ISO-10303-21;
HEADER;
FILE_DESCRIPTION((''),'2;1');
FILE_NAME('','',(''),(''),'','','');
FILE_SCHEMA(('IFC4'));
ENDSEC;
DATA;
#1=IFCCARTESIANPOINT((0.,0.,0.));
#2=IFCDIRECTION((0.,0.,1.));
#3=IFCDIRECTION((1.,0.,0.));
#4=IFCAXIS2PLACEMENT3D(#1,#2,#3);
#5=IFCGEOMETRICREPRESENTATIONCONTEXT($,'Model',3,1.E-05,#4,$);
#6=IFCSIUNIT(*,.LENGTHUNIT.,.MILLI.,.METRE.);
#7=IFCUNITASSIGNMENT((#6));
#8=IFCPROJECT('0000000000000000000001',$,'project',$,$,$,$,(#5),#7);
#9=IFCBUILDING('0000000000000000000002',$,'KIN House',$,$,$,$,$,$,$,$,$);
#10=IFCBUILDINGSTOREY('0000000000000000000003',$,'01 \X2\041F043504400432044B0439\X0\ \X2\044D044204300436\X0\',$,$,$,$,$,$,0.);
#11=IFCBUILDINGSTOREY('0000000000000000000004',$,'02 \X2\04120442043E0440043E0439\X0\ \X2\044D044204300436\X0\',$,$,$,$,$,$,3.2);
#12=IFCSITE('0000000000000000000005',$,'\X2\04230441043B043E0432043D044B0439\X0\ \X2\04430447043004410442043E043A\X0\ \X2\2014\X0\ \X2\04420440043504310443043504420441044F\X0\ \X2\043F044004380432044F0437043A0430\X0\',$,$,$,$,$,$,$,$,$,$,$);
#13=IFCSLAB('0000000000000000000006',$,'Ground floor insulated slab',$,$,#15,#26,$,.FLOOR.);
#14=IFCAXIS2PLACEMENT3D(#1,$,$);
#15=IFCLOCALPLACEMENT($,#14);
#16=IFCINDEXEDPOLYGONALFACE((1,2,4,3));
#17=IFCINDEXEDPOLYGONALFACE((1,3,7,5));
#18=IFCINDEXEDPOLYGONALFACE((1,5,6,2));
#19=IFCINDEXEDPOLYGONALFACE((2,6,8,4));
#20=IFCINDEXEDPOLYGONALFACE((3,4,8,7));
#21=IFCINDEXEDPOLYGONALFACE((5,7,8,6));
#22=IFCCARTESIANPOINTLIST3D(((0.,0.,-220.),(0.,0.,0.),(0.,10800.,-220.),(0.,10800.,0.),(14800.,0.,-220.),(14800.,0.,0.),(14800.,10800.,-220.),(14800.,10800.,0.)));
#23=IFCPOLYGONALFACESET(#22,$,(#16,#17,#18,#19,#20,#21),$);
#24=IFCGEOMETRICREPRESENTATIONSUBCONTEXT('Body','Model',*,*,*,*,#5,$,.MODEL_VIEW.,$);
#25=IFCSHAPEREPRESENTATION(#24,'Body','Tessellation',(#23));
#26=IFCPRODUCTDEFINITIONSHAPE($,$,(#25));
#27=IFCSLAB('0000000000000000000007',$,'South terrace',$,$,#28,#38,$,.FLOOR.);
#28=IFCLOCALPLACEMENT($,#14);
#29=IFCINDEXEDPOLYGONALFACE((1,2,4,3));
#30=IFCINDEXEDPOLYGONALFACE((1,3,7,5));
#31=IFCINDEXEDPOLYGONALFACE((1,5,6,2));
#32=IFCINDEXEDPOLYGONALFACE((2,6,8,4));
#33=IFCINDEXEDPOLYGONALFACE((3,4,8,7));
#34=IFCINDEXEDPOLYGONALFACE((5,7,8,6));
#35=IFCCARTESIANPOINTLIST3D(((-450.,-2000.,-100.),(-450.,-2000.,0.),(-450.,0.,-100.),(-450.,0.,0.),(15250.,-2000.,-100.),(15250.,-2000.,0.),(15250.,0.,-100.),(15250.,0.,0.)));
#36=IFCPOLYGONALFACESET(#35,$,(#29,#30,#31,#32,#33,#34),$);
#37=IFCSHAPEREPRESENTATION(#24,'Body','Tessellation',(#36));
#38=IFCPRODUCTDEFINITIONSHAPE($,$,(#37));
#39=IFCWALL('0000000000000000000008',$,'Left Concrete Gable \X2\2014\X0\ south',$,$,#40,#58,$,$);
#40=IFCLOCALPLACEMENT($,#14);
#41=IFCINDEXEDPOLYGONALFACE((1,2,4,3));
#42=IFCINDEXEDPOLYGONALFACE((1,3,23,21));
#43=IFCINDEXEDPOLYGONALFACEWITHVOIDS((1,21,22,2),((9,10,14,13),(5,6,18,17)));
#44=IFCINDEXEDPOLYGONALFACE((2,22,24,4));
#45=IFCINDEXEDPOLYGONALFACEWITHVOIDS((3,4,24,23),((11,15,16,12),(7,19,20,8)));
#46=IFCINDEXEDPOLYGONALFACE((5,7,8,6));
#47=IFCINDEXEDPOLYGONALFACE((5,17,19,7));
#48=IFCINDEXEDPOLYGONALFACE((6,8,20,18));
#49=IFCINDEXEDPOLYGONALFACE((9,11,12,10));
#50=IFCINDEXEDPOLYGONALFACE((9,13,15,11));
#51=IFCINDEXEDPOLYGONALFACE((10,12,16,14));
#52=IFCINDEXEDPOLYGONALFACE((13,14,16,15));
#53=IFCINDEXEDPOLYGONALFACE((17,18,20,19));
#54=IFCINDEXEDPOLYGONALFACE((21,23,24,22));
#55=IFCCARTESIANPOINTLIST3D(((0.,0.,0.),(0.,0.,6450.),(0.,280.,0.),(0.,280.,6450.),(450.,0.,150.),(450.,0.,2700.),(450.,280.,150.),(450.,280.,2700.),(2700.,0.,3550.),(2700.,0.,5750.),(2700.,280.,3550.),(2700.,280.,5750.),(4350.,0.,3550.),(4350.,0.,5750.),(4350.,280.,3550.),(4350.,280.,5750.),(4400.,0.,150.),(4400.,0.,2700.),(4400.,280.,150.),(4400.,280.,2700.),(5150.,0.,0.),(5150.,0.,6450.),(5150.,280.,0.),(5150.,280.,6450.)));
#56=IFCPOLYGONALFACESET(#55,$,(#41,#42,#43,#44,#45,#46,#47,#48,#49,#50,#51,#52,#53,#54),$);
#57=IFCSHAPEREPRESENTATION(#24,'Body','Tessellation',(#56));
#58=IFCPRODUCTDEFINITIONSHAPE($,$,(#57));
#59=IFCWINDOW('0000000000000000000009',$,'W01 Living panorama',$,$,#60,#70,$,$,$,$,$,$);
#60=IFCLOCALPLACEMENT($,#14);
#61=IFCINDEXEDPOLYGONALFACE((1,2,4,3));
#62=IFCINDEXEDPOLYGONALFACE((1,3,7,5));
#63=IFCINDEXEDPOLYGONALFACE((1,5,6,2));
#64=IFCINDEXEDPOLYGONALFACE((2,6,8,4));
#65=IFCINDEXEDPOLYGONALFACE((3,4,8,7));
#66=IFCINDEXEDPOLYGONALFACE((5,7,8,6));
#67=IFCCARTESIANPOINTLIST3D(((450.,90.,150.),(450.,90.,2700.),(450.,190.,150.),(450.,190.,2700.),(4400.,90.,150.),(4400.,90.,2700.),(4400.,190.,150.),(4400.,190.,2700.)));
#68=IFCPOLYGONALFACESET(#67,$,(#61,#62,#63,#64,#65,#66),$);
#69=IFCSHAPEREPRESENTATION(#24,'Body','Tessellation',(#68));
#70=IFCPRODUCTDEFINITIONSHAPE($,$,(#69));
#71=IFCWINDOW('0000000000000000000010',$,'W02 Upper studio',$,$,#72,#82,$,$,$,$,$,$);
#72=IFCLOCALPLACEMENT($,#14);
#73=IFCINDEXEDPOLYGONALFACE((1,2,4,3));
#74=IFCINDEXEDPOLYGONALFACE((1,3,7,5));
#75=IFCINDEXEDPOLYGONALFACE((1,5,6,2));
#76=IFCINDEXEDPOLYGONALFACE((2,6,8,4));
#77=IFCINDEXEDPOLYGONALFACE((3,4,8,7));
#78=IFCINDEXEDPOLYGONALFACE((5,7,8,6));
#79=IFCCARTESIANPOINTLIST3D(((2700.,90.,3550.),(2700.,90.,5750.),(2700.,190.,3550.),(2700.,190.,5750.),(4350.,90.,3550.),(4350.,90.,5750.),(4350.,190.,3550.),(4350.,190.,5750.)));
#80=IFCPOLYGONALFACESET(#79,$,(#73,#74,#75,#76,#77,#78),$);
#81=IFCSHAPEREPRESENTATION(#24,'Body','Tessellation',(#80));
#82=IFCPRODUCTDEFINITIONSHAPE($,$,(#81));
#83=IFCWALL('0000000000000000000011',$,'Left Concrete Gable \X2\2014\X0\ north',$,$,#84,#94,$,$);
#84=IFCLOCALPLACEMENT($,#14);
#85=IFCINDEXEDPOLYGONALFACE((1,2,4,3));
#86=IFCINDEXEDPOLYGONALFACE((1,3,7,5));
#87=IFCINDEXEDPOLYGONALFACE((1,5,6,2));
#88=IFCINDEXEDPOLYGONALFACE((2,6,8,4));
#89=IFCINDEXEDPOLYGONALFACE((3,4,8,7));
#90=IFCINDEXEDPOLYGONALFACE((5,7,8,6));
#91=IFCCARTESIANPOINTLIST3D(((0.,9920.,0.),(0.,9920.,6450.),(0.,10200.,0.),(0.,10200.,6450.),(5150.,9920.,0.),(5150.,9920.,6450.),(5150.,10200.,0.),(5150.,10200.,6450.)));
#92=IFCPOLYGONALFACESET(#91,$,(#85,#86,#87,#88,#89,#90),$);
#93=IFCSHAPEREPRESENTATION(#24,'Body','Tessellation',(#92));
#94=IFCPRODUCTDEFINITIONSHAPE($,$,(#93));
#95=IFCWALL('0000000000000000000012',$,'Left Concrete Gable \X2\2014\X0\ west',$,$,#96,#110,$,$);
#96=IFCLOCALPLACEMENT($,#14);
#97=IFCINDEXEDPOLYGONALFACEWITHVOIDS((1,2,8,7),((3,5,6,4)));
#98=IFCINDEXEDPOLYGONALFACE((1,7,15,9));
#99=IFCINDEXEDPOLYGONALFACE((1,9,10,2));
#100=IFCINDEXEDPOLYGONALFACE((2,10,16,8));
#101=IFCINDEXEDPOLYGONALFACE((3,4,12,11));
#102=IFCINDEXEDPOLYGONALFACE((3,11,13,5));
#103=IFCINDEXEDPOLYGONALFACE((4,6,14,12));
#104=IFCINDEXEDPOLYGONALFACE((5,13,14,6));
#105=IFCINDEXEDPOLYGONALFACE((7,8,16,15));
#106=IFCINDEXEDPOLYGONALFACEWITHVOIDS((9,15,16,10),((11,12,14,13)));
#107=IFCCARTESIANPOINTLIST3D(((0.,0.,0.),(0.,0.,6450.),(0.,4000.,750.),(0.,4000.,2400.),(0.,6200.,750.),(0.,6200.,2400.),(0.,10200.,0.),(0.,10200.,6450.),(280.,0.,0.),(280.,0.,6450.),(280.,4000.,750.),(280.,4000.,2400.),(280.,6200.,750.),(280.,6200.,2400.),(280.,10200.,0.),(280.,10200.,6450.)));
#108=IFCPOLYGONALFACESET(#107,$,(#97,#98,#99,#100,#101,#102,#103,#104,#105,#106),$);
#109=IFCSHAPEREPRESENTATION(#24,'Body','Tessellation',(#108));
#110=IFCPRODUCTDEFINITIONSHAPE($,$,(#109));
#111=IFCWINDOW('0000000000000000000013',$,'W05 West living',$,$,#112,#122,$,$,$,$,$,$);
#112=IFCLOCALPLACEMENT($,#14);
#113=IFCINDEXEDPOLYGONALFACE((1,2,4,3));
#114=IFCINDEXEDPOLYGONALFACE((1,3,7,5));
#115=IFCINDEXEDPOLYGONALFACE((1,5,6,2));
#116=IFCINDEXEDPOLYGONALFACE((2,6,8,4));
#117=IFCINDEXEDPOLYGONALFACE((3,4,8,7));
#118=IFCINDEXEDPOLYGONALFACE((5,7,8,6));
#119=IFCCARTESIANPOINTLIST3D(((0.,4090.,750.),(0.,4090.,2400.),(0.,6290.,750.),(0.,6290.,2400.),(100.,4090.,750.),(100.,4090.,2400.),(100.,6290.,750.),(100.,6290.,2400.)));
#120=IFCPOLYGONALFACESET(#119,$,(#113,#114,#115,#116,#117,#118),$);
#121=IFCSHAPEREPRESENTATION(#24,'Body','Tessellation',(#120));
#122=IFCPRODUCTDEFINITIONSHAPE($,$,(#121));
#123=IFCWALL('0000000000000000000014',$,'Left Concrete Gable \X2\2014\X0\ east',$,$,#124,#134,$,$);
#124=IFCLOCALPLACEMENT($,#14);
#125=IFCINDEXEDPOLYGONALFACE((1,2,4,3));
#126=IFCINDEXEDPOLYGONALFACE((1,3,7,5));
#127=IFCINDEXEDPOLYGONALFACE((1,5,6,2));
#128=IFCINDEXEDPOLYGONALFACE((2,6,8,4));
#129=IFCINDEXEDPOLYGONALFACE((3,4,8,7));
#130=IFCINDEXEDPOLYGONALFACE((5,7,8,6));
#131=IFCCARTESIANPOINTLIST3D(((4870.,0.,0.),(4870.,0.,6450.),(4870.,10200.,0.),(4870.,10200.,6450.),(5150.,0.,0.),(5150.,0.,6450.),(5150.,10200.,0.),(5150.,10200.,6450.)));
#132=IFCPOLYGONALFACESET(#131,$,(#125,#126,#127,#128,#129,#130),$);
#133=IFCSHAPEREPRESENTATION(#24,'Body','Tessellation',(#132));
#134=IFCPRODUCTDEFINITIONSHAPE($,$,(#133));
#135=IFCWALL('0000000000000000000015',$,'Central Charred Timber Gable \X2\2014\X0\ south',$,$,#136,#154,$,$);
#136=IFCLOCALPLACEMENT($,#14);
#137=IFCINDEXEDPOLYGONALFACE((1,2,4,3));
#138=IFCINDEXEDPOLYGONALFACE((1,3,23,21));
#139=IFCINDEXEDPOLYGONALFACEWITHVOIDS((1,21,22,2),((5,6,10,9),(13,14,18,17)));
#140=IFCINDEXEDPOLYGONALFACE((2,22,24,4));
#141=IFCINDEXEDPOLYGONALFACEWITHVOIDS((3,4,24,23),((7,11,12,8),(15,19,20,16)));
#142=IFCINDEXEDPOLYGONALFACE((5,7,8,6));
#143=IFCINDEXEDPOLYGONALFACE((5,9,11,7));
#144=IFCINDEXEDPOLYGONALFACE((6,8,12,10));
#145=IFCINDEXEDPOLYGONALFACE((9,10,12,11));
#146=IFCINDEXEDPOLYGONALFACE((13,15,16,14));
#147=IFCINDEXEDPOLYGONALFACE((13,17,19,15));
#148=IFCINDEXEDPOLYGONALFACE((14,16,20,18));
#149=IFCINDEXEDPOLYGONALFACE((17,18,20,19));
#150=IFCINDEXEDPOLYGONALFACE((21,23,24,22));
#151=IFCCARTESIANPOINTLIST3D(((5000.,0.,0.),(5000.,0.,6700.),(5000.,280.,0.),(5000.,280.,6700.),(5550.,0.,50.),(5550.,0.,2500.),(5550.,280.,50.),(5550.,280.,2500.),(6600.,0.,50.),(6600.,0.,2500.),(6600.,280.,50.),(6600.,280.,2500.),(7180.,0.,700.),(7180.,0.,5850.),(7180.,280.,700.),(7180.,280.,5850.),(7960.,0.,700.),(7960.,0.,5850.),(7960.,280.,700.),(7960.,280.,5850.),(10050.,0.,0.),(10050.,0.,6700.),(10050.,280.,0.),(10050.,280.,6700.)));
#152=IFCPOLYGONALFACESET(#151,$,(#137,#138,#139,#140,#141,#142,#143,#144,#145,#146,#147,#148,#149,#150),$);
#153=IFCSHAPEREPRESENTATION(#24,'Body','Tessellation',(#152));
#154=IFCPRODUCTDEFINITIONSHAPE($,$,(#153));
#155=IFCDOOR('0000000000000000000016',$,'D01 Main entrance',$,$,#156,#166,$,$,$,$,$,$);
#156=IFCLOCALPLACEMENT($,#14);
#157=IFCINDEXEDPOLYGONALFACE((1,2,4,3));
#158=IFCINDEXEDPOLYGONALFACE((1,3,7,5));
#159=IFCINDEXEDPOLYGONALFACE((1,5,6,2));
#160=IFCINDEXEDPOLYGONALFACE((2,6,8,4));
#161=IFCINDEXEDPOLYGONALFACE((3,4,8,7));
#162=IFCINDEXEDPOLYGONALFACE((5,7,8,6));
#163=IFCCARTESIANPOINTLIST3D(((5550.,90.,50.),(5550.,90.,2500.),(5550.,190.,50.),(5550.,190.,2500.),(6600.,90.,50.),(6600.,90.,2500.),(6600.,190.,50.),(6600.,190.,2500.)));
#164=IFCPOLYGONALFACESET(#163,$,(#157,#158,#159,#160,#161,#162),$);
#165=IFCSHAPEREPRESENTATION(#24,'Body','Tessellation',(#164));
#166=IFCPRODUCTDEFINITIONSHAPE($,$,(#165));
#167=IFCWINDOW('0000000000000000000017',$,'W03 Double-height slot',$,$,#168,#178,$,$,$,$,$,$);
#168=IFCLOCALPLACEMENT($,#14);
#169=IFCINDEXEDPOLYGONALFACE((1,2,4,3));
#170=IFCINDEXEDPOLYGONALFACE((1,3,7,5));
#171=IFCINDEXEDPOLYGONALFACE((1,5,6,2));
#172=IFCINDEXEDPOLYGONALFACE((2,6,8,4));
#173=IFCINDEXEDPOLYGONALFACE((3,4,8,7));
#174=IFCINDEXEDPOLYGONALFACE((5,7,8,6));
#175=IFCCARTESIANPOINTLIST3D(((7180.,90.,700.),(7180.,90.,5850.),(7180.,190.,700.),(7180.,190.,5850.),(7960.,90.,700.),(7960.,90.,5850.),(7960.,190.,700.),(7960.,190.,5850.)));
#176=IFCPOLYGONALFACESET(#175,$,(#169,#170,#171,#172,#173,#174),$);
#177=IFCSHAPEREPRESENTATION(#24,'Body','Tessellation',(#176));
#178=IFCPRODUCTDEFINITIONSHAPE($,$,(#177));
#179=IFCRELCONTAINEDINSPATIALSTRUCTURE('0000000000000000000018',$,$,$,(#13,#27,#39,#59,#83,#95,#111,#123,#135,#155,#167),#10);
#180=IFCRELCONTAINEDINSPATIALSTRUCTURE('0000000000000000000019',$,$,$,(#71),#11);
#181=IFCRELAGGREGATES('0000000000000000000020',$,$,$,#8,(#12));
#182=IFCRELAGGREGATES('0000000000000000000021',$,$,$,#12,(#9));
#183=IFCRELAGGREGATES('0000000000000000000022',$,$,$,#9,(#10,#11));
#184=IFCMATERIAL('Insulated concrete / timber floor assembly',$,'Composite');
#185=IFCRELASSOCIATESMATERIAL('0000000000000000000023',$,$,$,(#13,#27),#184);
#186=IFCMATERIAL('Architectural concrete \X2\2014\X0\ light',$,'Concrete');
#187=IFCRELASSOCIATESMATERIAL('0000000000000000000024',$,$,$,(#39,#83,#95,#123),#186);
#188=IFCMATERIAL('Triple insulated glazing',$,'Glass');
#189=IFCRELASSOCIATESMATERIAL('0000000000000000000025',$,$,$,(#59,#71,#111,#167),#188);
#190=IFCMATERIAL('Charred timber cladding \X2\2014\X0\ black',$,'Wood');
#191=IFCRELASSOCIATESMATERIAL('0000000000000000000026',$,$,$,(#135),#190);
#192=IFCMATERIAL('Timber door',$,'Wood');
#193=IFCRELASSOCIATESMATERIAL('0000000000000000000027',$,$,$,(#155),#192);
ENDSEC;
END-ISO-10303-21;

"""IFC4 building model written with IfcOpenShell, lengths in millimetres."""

from ifc_helpers import new_model, si_unit, frame, origin_with_axes, place, context, subcontext, project, spatial, indexed_curve, outline, extrude, material, element, fill, save


model = new_model("IFC4")

# Units and contexts
model_context = context("Model", 3, precision=1e-05, world=origin_with_axes())
body_context = subcontext(model_context, "Body", "Model", "MODEL_VIEW")
ifc_project = project(units=[si_unit("LENGTHUNIT", "METRE", prefix="MILLI")], contexts=[model_context])

# Site, building, storey
site = spatial("IfcSite", under=ifc_project, Name="Условный участок — требуется привязка")
building = spatial("IfcBuilding", under=site, Name="KIN House")
storey_1 = spatial("IfcBuildingStorey", under=building, Name="01 Первый этаж", Elevation=0.0)

# Slabs
ifc_material_1 = material(Name="Insulated concrete / timber floor assembly", Category="Composite")
slab_1_placement = place(None, frame((0.0, 0.0, -220.0), z_axis=(0.0, 0.0, 1.0), x_axis=(1.0, 0.0, 0.0)))
element("IfcSlab", 1, at=slab_1_placement, inside=storey_1, material=ifc_material_1, Name="Ground floor insulated slab", PredefinedType="FLOOR", context=body_context, shape_type="SweptSolid", body=[
    extrude(outline(indexed_curve([(0.0, 0.0), (14800.0, 0.0), (14800.0, 10800.0), (0.0, 10800.0)])), None, (0.0, 0.0, 1.0), 220.0),
])
slab_2_placement = place(None, frame((-450.0, -2000.0, -100.0), z_axis=(0.0, 0.0, 1.0), x_axis=(1.0, 0.0, 0.0)))
element("IfcSlab", 2, at=slab_2_placement, inside=storey_1, material=ifc_material_1, Name="South terrace", PredefinedType="FLOOR", context=body_context, shape_type="SweptSolid", body=[
    extrude(outline(indexed_curve([(0.0, 0.0), (15700.0, 0.0), (15700.0, 2000.0), (0.0, 2000.0)])), None, (0.0, 0.0, 1.0), 100.0),
])

# Wall, openings, window
ifc_material_2 = material(Name="Architectural concrete — light", Category="Concrete")
wall_1_placement = place(None, origin_with_axes())
wall_1 = element("IfcWall", 3, at=wall_1_placement, inside=storey_1, material=ifc_material_2, Name="Left Concrete Gable — south", context=body_context, shape_type="SweptSolid", body=[
    extrude(outline(indexed_curve([(0.0, 0.0), (0.0, 280.0), (5150.0, 280.0), (5150.0, 0.0), (0.0, 0.0)], self_intersect=False)), origin_with_axes(), (0.0, 0.0, 1.0), 6450.0),
])
opening_1_placement = place(wall_1_placement, frame((450.0, 0.0, 150.0), z_axis=(0.0, 0.0, 1.0), x_axis=(1.0, 0.0, 0.0)))
opening_1 = element("IfcOpeningElement", 4, at=opening_1_placement, cuts=wall_1, context=body_context, shape_type="SweptSolid", body=[
    extrude(outline(indexed_curve([(0.0, 0.0), (0.0, 380.0), (3950.0, 380.0), (3950.0, 0.0), (0.0, 0.0)], self_intersect=False)), origin_with_axes(), (0.0, 0.0, 1.0), 2550.0),
])
opening_2_placement = place(wall_1_placement, frame((2700.0, 0.0, 3550.0), z_axis=(0.0, 0.0, 1.0), x_axis=(1.0, 0.0, 0.0)))
opening_2 = element("IfcOpeningElement", 5, at=opening_2_placement, cuts=wall_1, context=body_context, shape_type="SweptSolid", body=[
    extrude(outline(indexed_curve([(0.0, 0.0), (0.0, 380.0), (1650.0, 380.0), (1650.0, 0.0), (0.0, 0.0)], self_intersect=False)), origin_with_axes(), (0.0, 0.0, 1.0), 2200.0),
])
ifc_material_3 = material(Name="Triple insulated glazing", Category="Glass")
window_1_placement = place(None, frame((450.0, 90.0, 150.0), z_axis=(0.0, 0.0, 1.0), x_axis=(1.0, 0.0, 0.0)))
window_1 = element("IfcWindow", 6, at=window_1_placement, inside=storey_1, material=ifc_material_3, Name="W01 Living panorama", context=body_context, shape_type="SweptSolid", body=[
    extrude(outline(indexed_curve([(0.0, 0.0), (0.0, 100.0), (3950.0, 100.0), (3950.0, 0.0), (0.0, 0.0)], self_intersect=False)), origin_with_axes(), (0.0, 0.0, 1.0), 2550.0),
])
fill(opening_1, window_1)

# Shared definitions
storey_2 = spatial("IfcBuildingStorey", under=building, Name="02 Второй этаж", Elevation=3.2)

# Window
window_2_placement = place(None, frame((2700.0, 90.0, 3550.0), z_axis=(0.0, 0.0, 1.0), x_axis=(1.0, 0.0, 0.0)))
window_2 = element("IfcWindow", 7, at=window_2_placement, inside=storey_2, material=ifc_material_3, Name="W02 Upper studio", context=body_context, shape_type="SweptSolid", body=[
    extrude(outline(indexed_curve([(0.0, 0.0), (0.0, 100.0), (1650.0, 100.0), (1650.0, 0.0), (0.0, 0.0)], self_intersect=False)), origin_with_axes(), (0.0, 0.0, 1.0), 2200.0),
])
fill(opening_2, window_2)

# Wall
wall_2_placement = place(None, frame((5150.0, 10200.0, 0.0), z_axis=(0.0, 0.0, 1.0), x_axis=(-1.0, 0.0, 0.0)))
element("IfcWall", 8, at=wall_2_placement, inside=storey_1, material=ifc_material_2, Name="Left Concrete Gable — north", context=body_context, shape_type="SweptSolid", body=[
    extrude(outline(indexed_curve([(0.0, 0.0), (0.0, 280.0), (5150.0, 280.0), (5150.0, 0.0), (0.0, 0.0)], self_intersect=False)), origin_with_axes(), (0.0, 0.0, 1.0), 6450.0),
])

# Wall, opening, window
wall_3_placement = place(None, frame((0.0, 10200.0, 0.0), z_axis=(0.0, 0.0, 1.0), x_axis=(0.0, -1.0, 0.0)))
wall_3 = element("IfcWall", 9, at=wall_3_placement, inside=storey_1, material=ifc_material_2, Name="Left Concrete Gable — west", context=body_context, shape_type="SweptSolid", body=[
    extrude(outline(indexed_curve([(0.0, 0.0), (0.0, 280.0), (10200.0, 280.0), (10200.0, 0.0), (0.0, 0.0)], self_intersect=False)), origin_with_axes(), (0.0, 0.0, 1.0), 6450.0),
])
opening_3_placement = place(wall_3_placement, frame((4000.0, 0.0, 750.0), z_axis=(0.0, 0.0, 1.0), x_axis=(1.0, 0.0, 0.0)))
opening_3 = element("IfcOpeningElement", 10, at=opening_3_placement, cuts=wall_3, context=body_context, shape_type="SweptSolid", body=[
    extrude(outline(indexed_curve([(0.0, 0.0), (0.0, 380.0), (2200.0, 380.0), (2200.0, 0.0), (0.0, 0.0)], self_intersect=False)), origin_with_axes(), (0.0, 0.0, 1.0), 1650.0),
])
window_3_placement = place(None, frame((0.0, 6290.0, 750.0), z_axis=(0.0, 0.0, 1.0), x_axis=(0.0, -1.0, 0.0)))
window_3 = element("IfcWindow", 11, at=window_3_placement, inside=storey_1, material=ifc_material_3, Name="W05 West living", context=body_context, shape_type="SweptSolid", body=[
    extrude(outline(indexed_curve([(0.0, 0.0), (0.0, 100.0), (2200.0, 100.0), (2200.0, 0.0), (0.0, 0.0)], self_intersect=False)), origin_with_axes(), (0.0, 0.0, 1.0), 1650.0),
])
fill(opening_3, window_3)

# Wall
wall_4_placement = place(None, frame((5150.0, 0.0, 0.0), z_axis=(0.0, 0.0, 1.0), x_axis=(0.0, 1.0, 0.0)))
element("IfcWall", 12, at=wall_4_placement, inside=storey_1, material=ifc_material_2, Name="Left Concrete Gable — east", context=body_context, shape_type="SweptSolid", body=[
    extrude(outline(indexed_curve([(0.0, 0.0), (0.0, 280.0), (10200.0, 280.0), (10200.0, 0.0), (0.0, 0.0)], self_intersect=False)), origin_with_axes(), (0.0, 0.0, 1.0), 6450.0),
])

# Wall, openings, door, window
ifc_material_4 = material(Name="Charred timber cladding — black", Category="Wood")
wall_5_placement = place(None, frame((5000.0, 0.0, 0.0), z_axis=(0.0, 0.0, 1.0), x_axis=(1.0, 0.0, 0.0)))
wall_5 = element("IfcWall", 13, at=wall_5_placement, inside=storey_1, material=ifc_material_4, Name="Central Charred Timber Gable — south", context=body_context, shape_type="SweptSolid", body=[
    extrude(outline(indexed_curve([(0.0, 0.0), (0.0, 280.0), (5050.0, 280.0), (5050.0, 0.0), (0.0, 0.0)], self_intersect=False)), origin_with_axes(), (0.0, 0.0, 1.0), 6700.0),
])
opening_4_placement = place(wall_5_placement, frame((550.0, 0.0, 50.0), z_axis=(0.0, 0.0, 1.0), x_axis=(1.0, 0.0, 0.0)))
opening_4 = element("IfcOpeningElement", 14, at=opening_4_placement, cuts=wall_5, context=body_context, shape_type="SweptSolid", body=[
    extrude(outline(indexed_curve([(0.0, 0.0), (0.0, 380.0), (1050.0, 380.0), (1050.0, 0.0), (0.0, 0.0)], self_intersect=False)), origin_with_axes(), (0.0, 0.0, 1.0), 2450.0),
])
opening_5_placement = place(wall_5_placement, frame((2180.0, 0.0, 700.0), z_axis=(0.0, 0.0, 1.0), x_axis=(1.0, 0.0, 0.0)))
opening_5 = element("IfcOpeningElement", 15, at=opening_5_placement, cuts=wall_5, context=body_context, shape_type="SweptSolid", body=[
    extrude(outline(indexed_curve([(0.0, 0.0), (0.0, 380.0), (780.0, 380.0), (780.0, 0.0), (0.0, 0.0)], self_intersect=False)), origin_with_axes(), (0.0, 0.0, 1.0), 5150.0),
])
ifc_material_5 = material(Name="Timber door", Category="Wood")
door_placement = place(None, frame((5550.0, 90.0, 50.0), z_axis=(0.0, 0.0, 1.0), x_axis=(1.0, 0.0, 0.0)))
door = element("IfcDoor", 16, at=door_placement, inside=storey_1, material=ifc_material_5, Name="D01 Main entrance", context=body_context, shape_type="SweptSolid", body=[
    extrude(outline(indexed_curve([(0.0, 0.0), (0.0, 100.0), (1050.0, 100.0), (1050.0, 0.0), (0.0, 0.0)], self_intersect=False)), origin_with_axes(), (0.0, 0.0, 1.0), 2450.0),
])
fill(opening_4, door)
window_4_placement = place(None, frame((7180.0, 90.0, 700.0), z_axis=(0.0, 0.0, 1.0), x_axis=(1.0, 0.0, 0.0)))
window_4 = element("IfcWindow", 17, at=window_4_placement, inside=storey_1, material=ifc_material_3, Name="W03 Double-height slot", context=body_context, shape_type="SweptSolid", body=[
    extrude(outline(indexed_curve([(0.0, 0.0), (0.0, 100.0), (780.0, 100.0), (780.0, 0.0), (0.0, 0.0)], self_intersect=False)), origin_with_axes(), (0.0, 0.0, 1.0), 5150.0),
])
fill(opening_5, window_4)

save(model, "model.ifc")
